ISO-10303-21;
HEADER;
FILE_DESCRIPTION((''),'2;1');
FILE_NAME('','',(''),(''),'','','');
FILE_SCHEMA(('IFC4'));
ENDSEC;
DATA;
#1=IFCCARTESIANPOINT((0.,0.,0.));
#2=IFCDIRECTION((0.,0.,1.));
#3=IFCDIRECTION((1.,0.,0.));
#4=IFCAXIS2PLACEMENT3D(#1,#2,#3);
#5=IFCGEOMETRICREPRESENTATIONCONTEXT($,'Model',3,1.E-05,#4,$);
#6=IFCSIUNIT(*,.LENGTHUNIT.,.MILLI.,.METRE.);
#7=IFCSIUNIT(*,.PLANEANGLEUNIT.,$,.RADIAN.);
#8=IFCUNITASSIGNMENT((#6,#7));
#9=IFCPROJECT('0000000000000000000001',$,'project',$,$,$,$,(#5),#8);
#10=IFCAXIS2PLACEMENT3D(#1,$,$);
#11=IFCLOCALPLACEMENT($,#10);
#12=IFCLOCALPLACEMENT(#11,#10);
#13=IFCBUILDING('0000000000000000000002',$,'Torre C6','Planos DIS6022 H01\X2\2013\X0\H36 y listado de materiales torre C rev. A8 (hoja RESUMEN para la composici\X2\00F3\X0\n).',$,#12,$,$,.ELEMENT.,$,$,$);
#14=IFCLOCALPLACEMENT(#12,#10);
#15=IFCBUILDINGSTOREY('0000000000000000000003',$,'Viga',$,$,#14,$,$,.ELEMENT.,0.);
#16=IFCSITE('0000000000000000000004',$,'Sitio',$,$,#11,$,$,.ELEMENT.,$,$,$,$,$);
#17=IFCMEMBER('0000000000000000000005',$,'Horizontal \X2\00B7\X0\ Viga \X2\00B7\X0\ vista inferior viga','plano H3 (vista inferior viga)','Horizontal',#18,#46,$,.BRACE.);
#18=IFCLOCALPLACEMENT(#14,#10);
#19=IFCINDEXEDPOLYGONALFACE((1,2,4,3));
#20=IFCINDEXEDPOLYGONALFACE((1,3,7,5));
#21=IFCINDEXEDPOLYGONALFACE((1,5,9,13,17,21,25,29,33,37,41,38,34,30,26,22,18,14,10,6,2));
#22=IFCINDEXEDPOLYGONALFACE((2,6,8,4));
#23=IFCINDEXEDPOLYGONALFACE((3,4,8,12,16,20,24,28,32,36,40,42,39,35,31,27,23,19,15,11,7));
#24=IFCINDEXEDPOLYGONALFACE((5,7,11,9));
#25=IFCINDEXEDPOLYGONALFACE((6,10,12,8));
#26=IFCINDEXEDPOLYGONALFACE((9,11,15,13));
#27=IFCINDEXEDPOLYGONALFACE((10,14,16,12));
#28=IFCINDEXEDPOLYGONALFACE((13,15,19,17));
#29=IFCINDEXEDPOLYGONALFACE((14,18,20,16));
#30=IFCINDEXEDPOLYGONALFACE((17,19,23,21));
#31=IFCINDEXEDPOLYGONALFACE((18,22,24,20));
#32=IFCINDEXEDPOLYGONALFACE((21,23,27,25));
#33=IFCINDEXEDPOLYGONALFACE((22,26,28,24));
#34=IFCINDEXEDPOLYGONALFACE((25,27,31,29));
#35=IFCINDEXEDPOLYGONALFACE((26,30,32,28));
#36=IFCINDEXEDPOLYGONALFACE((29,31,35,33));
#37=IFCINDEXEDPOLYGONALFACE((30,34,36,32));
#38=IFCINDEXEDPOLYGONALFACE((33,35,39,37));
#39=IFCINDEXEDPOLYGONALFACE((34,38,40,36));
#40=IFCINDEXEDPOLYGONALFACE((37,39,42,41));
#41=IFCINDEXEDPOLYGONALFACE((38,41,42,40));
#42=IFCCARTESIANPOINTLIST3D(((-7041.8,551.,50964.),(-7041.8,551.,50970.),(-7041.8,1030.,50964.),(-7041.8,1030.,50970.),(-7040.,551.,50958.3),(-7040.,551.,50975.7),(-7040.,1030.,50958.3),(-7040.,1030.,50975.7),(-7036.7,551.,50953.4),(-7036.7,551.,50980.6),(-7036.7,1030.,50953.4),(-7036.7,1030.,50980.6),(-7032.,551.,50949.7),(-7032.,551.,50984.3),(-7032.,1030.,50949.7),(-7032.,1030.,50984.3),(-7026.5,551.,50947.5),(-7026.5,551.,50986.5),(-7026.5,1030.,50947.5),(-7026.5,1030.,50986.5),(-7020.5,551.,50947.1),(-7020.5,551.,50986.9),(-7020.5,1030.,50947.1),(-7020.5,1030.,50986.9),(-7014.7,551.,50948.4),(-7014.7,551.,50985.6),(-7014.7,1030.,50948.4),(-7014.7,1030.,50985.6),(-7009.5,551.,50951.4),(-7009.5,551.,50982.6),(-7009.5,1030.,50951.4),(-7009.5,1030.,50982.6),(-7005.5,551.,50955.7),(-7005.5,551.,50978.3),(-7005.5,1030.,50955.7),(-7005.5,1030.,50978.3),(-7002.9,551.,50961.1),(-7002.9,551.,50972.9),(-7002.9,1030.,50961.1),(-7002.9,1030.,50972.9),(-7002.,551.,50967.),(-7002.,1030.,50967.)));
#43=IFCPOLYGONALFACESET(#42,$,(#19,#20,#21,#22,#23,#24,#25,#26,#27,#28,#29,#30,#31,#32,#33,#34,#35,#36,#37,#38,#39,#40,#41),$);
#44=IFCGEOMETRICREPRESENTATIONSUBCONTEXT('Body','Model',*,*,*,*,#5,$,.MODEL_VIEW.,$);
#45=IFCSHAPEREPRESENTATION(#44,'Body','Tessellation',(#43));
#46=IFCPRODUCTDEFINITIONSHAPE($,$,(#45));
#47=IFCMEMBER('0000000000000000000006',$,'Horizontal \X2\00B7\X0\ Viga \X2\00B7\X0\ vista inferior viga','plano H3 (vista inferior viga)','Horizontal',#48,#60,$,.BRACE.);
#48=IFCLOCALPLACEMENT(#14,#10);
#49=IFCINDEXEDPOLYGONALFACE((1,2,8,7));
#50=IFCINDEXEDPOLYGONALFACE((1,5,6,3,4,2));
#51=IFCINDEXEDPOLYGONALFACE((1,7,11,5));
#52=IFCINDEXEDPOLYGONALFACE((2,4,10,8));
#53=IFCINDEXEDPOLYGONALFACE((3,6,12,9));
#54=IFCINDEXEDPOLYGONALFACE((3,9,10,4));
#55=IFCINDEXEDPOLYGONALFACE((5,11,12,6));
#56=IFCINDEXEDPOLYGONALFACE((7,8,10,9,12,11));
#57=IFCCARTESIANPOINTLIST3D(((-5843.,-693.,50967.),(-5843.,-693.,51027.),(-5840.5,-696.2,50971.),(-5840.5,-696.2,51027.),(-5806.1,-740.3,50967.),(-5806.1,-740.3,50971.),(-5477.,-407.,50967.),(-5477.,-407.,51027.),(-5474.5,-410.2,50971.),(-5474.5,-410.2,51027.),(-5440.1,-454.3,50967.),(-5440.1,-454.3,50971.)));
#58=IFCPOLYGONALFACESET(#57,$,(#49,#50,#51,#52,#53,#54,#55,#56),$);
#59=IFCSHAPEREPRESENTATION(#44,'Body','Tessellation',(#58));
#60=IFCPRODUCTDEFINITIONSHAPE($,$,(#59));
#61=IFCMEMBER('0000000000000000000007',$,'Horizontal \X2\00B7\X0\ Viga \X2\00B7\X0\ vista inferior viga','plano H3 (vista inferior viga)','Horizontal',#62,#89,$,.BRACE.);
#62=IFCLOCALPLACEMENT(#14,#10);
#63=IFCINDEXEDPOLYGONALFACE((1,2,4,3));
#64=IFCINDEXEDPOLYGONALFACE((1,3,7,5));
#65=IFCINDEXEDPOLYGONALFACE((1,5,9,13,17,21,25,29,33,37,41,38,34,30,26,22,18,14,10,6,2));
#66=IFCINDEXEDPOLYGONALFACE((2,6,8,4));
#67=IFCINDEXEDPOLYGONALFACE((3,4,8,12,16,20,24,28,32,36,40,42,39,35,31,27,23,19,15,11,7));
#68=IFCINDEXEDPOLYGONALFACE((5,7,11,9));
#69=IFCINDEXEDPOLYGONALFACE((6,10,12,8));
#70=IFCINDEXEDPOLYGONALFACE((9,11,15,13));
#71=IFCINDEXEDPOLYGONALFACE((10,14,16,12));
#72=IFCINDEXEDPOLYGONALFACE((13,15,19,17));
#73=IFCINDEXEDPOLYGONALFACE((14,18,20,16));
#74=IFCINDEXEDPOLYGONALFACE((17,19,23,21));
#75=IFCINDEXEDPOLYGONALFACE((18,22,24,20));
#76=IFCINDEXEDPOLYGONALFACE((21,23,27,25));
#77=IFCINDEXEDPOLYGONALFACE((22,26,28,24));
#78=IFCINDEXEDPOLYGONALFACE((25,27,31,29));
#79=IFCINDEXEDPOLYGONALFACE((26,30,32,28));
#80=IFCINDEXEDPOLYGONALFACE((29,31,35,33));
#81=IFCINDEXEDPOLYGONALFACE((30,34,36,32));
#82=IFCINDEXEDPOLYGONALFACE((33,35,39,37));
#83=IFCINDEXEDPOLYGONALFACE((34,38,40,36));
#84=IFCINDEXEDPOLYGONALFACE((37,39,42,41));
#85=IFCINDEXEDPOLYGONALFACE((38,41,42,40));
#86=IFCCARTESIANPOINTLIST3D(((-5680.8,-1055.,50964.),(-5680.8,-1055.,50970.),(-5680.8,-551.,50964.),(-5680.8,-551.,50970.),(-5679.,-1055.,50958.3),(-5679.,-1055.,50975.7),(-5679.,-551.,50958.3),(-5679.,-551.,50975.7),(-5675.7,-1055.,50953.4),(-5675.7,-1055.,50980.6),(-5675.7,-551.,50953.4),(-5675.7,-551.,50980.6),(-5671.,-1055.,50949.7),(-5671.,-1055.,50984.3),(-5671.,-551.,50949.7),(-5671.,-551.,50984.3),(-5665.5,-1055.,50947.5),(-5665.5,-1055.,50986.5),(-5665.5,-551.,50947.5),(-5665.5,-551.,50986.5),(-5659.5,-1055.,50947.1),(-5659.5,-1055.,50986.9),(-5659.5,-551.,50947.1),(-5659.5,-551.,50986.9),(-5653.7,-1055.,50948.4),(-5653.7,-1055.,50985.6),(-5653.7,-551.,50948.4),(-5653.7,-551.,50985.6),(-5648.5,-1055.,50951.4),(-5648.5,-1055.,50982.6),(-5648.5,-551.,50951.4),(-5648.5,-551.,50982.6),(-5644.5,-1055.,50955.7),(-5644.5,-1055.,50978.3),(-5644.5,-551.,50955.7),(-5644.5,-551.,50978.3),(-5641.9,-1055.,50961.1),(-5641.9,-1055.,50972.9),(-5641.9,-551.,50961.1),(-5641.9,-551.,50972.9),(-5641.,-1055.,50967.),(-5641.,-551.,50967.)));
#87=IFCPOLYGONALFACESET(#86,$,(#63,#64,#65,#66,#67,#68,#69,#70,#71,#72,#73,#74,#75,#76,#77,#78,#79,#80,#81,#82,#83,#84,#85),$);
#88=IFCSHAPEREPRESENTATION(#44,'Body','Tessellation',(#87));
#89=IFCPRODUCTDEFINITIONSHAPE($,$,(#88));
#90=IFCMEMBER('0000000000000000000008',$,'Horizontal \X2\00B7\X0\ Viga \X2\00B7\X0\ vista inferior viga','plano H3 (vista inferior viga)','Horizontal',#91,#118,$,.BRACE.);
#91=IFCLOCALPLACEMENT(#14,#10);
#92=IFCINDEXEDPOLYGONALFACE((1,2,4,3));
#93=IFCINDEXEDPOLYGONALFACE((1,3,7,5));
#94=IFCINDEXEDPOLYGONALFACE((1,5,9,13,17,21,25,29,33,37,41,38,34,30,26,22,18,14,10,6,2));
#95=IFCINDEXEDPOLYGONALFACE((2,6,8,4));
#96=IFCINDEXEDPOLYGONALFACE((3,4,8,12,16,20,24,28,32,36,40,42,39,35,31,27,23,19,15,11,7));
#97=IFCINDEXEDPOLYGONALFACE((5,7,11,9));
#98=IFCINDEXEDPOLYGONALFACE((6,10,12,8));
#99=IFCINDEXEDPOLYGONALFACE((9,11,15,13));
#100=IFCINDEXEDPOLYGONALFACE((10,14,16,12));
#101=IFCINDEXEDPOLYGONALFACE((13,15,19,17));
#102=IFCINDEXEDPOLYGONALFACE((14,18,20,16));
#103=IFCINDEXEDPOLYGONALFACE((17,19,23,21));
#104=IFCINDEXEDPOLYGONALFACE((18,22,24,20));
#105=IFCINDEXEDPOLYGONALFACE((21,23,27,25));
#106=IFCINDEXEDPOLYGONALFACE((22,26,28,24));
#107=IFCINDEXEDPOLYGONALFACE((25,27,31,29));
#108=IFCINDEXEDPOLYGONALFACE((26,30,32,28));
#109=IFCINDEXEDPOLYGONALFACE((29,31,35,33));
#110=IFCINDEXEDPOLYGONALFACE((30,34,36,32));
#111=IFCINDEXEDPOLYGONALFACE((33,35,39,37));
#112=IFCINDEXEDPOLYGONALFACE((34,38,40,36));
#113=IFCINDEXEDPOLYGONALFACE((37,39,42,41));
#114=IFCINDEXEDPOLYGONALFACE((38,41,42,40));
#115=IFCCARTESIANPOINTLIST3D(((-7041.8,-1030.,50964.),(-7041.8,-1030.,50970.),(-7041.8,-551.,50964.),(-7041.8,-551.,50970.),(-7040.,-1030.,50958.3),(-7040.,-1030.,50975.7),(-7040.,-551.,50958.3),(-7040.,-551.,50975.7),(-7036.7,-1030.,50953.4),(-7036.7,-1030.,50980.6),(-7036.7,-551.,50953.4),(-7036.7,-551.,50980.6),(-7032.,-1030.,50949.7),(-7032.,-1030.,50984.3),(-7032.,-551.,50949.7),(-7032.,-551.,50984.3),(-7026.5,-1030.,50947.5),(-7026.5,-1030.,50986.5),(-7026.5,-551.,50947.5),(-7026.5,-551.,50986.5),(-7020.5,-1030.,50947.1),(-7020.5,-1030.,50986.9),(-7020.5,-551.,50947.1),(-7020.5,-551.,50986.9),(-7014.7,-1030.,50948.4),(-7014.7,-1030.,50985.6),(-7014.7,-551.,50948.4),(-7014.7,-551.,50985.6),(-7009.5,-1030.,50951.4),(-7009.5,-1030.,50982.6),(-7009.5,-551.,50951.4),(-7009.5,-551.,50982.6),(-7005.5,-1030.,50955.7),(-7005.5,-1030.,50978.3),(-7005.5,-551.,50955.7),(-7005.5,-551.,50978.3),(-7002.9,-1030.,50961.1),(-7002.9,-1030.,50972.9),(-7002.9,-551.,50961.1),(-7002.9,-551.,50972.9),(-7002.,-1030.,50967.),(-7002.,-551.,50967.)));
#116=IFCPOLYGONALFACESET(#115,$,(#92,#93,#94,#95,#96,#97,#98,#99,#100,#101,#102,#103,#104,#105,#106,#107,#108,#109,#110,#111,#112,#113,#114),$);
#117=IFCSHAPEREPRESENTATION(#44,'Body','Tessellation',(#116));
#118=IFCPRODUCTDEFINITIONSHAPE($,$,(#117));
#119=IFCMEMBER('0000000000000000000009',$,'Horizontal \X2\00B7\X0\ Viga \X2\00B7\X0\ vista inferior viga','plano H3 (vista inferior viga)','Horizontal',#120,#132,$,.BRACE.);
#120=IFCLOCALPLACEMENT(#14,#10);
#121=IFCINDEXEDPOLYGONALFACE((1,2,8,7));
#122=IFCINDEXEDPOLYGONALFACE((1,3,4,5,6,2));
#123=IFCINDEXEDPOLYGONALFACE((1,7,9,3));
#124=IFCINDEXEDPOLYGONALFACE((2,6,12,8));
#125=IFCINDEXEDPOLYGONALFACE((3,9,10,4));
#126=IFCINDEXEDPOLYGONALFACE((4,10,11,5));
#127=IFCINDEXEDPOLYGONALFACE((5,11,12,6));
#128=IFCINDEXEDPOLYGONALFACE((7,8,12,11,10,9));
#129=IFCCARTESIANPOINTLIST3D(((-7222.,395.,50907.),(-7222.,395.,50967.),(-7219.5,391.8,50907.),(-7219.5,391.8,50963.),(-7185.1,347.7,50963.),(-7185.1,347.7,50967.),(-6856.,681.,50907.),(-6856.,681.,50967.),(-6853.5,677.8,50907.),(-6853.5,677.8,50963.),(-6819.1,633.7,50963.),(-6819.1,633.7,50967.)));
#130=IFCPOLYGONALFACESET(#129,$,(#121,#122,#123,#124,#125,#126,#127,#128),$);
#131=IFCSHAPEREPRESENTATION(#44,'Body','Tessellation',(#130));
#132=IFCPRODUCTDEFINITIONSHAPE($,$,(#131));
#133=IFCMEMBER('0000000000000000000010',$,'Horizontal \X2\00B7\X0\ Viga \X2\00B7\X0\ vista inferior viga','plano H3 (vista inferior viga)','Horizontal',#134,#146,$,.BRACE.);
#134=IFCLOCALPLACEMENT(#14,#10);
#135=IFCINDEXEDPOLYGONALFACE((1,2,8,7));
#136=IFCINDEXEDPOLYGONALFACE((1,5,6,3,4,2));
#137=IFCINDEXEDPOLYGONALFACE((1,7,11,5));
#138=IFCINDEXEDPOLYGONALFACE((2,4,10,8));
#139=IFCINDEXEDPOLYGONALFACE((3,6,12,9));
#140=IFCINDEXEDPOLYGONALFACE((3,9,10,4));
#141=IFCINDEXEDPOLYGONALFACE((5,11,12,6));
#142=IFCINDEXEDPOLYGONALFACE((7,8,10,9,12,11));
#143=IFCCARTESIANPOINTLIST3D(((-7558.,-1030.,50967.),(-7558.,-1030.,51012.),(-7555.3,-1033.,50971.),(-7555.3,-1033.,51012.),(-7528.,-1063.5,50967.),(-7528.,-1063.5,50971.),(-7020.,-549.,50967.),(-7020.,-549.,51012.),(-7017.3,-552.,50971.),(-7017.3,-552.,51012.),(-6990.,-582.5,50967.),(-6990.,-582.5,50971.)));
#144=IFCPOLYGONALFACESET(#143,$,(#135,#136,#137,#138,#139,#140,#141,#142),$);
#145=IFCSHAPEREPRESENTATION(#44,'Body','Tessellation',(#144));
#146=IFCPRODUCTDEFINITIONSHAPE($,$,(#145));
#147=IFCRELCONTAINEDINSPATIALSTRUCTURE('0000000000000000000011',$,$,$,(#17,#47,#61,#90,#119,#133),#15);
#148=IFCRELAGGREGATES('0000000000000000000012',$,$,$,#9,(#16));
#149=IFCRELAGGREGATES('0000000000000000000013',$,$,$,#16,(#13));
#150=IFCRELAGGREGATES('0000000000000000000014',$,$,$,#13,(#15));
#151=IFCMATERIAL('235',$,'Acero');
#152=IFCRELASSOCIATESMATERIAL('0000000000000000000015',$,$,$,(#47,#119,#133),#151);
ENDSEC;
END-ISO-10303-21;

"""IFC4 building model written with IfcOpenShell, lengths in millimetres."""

from ifc_helpers import new_model, si_unit, frame, frame_2d, origin, origin_with_axes, place, context, subcontext, project, spatial, circle, l_section, extrude, material, element, save


model = new_model("IFC4")

# Units and contexts
model_context = context("Model", 3, precision=1e-05, world=origin_with_axes())
body_context = subcontext(model_context, "Body", "Model", "MODEL_VIEW")
ifc_project = project(units=[si_unit("LENGTHUNIT", "METRE", prefix="MILLI"), si_unit("PLANEANGLEUNIT", "RADIAN")], contexts=[model_context])

# Site, building, storey
site_placement = place(None, origin())
site = spatial("IfcSite", under=ifc_project, at=site_placement, Name="Sitio", CompositionType="ELEMENT")
building_placement = place(site_placement, origin())
building = spatial("IfcBuilding", under=site, at=building_placement, Name="Torre C6", Description="Planos DIS6022 H01–H36 y listado de materiales torre C rev. A8 (hoja RESUMEN para la composición).", CompositionType="ELEMENT")
storey_placement = place(building_placement, origin())
storey = spatial("IfcBuildingStorey", under=building, at=storey_placement, Name="Viga", CompositionType="ELEMENT", Elevation=0.0)

# Members
ifc_material_1 = material(Name="235", Category="Acero")
member_1_placement = place(storey_placement, frame((-7022.0, 551.0, 50967.0), z_axis=(0.0, 1.0, 0.0), x_axis=(1.0, 0.0, 0.0)))
element("IfcMember", 1, at=member_1_placement, inside=storey, Name="Horizontal · Viga · vista inferior viga", Description="plano H3 (vista inferior viga)", ObjectType="Horizontal", PredefinedType="BRACE", context=body_context, shape_type="SweptSolid", body=[
    extrude(circle(Radius=20.0), None, (0.0, 0.0, 1.0), 479.0),
])
member_2_placement = place(storey_placement, frame((-5477.0, -407.0, 50967.0), z_axis=(-0.787959, -0.615728, 0.0), x_axis=(0.615728, -0.787959, 0.0)))
element("IfcMember", 2, at=member_2_placement, inside=storey, material=ifc_material_1, Name="Horizontal · Viga · vista inferior viga", Description="plano H3 (vista inferior viga)", ObjectType="Horizontal", PredefinedType="BRACE", context=body_context, shape_type="SweptSolid", body=[
    extrude(l_section(Depth=60.0, Width=60.0, Thickness=4.0, at=frame_2d((30.0, 30.0))), None, (0.0, 0.0, 1.0), 464.5),
])
member_3_placement = place(storey_placement, frame((-5661.0, -551.0, 50967.0), z_axis=(0.0, -1.0, 0.0), x_axis=(1.0, 0.0, 0.0)))
element("IfcMember", 3, at=member_3_placement, inside=storey, Name="Horizontal · Viga · vista inferior viga", Description="plano H3 (vista inferior viga)", ObjectType="Horizontal", PredefinedType="BRACE", context=body_context, shape_type="SweptSolid", body=[
    extrude(circle(Radius=20.0), None, (0.0, 0.0, 1.0), 504.0),
])
member_4_placement = place(storey_placement, frame((-7022.0, -551.0, 50967.0), z_axis=(0.0, -1.0, 0.0), x_axis=(1.0, 0.0, 0.0)))
element("IfcMember", 4, at=member_4_placement, inside=storey, Name="Horizontal · Viga · vista inferior viga", Description="plano H3 (vista inferior viga)", ObjectType="Horizontal", PredefinedType="BRACE", context=body_context, shape_type="SweptSolid", body=[
    extrude(circle(Radius=20.0), None, (0.0, 0.0, 1.0), 479.0),
])
member_5_placement = place(storey_placement, frame((-7222.0, 395.0, 50967.0), z_axis=(0.787959, 0.615728, 0.0), x_axis=(0.615728, -0.787959, 0.0)))
element("IfcMember", 5, at=member_5_placement, inside=storey, material=ifc_material_1, Name="Horizontal · Viga · vista inferior viga", Description="plano H3 (vista inferior viga)", ObjectType="Horizontal", PredefinedType="BRACE", context=body_context, shape_type="SweptSolid", body=[
    extrude(l_section(Depth=60.0, Width=60.0, Thickness=4.0, at=frame_2d((30.0, 30.0))), None, (0.0, 0.0, 1.0), 464.5),
])
member_6_placement = place(storey_placement, frame((-7020.0, -549.0, 50967.0), z_axis=(-0.745495, -0.666511, 0.0), x_axis=(0.666511, -0.745495, 0.0)))
element("IfcMember", 6, at=member_6_placement, inside=storey, material=ifc_material_1, Name="Horizontal · Viga · vista inferior viga", Description="plano H3 (vista inferior viga)", ObjectType="Horizontal", PredefinedType="BRACE", context=body_context, shape_type="SweptSolid", body=[
    extrude(l_section(Depth=45.0, Width=45.0, Thickness=4.0, at=frame_2d((22.5, 22.5))), None, (0.0, 0.0, 1.0), 721.7),
])

save(model, "model.ifc")
